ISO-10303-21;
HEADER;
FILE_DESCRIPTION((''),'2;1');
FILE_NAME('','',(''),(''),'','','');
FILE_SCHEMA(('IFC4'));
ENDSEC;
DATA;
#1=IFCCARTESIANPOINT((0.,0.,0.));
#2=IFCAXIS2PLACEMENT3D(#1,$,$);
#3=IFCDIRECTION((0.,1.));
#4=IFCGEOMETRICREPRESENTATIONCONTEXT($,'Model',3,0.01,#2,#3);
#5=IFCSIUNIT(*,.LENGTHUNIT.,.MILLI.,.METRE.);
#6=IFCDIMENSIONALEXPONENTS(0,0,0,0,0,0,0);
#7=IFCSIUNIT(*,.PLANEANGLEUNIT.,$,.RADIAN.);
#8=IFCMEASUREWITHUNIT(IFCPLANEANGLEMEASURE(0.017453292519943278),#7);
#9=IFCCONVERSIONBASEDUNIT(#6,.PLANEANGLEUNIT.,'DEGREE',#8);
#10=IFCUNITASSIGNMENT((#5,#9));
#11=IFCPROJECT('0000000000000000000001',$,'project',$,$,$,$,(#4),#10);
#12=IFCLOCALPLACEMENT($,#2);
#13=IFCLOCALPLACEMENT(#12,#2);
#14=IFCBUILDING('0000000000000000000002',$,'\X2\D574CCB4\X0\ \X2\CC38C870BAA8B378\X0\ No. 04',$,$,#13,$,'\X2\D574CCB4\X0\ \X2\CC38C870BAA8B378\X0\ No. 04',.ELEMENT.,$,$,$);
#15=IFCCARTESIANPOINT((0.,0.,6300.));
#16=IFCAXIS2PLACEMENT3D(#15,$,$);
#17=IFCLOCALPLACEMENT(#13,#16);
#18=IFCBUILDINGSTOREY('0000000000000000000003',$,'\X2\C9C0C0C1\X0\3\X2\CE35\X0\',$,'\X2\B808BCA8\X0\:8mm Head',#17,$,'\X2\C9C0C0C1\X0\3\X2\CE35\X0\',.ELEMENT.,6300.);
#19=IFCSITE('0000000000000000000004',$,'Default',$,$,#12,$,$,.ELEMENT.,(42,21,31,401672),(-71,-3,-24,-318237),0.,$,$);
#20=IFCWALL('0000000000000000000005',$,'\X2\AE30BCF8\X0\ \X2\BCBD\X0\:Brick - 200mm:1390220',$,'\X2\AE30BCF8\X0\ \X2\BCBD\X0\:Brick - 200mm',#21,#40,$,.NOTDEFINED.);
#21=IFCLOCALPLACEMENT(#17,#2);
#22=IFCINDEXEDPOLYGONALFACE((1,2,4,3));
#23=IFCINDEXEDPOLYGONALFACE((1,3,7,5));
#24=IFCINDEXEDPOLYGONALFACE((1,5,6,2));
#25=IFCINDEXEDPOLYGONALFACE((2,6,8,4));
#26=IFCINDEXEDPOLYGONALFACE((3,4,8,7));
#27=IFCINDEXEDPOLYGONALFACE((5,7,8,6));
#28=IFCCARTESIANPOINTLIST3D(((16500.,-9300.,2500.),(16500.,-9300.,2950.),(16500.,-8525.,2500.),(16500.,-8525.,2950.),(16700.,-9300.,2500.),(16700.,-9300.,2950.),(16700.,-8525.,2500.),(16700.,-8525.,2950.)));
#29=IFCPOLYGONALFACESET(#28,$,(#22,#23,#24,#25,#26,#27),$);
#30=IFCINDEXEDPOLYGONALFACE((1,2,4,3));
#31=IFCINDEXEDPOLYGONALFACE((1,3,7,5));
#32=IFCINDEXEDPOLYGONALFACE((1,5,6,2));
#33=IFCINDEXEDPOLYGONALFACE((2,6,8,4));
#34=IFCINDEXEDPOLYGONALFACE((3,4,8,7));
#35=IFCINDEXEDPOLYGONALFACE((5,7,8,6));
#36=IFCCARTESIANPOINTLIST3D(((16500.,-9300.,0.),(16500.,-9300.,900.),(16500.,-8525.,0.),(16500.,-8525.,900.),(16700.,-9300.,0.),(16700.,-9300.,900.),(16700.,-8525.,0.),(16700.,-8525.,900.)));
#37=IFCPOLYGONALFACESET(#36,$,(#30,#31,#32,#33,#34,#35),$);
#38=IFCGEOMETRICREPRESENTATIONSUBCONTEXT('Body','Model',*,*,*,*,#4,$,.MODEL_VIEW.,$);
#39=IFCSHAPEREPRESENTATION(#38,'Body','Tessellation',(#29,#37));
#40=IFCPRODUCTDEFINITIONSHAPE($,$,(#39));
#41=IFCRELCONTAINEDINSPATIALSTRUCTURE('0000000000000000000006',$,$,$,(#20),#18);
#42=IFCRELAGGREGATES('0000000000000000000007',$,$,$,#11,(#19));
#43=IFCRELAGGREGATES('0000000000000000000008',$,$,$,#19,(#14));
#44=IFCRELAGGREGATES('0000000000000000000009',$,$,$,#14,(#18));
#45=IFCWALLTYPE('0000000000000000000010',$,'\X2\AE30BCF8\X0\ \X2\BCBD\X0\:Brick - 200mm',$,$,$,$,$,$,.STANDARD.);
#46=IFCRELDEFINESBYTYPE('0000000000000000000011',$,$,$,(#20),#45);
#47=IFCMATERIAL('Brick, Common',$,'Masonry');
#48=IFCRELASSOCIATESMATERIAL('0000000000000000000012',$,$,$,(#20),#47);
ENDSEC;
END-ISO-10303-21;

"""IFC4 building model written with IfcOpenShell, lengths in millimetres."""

from ifc_helpers import new_model, entity, si_unit, converted_unit, direction, frame, origin, place, context, subcontext, project, spatial, indexed_curve, outline, extrude, material, type_object, element, save


model = new_model("IFC4")

# Units and contexts
model_context = context("Model", 3, precision=0.01, world=origin(), true_north=direction((0.0, 1.0)))
body_context = subcontext(model_context, "Body", "Model", "MODEL_VIEW")
ifc_project = project(units=[si_unit("LENGTHUNIT", "METRE", prefix="MILLI"), converted_unit("PLANEANGLEUNIT", "DEGREE", entity("IfcPlaneAngleMeasure", 0.017453292519943278), si_unit("PLANEANGLEUNIT", "RADIAN"), dimensions=[0, 0, 0, 0, 0, 0, 0])], contexts=[model_context])

# Site, building, storey
site_placement = place(None, origin())
site = spatial("IfcSite", under=ifc_project, at=site_placement, Name="Default", CompositionType="ELEMENT", RefLatitude=(42, 21, 31, 401672), RefLongitude=(-71, -3, -24, -318237), RefElevation=0.0)
building_placement = place(site_placement, origin())
building = spatial("IfcBuilding", under=site, at=building_placement, Name="해체 참조모델 No. 04", LongName="해체 참조모델 No. 04", CompositionType="ELEMENT")
storey_placement = place(building_placement, frame((0.0, 0.0, 6300.0)))
storey = spatial("IfcBuildingStorey", under=building, at=storey_placement, Name="지상3층", ObjectType="레벨:8mm Head", LongName="지상3층", CompositionType="ELEMENT", Elevation=6300.0)

# Shared definitions
ifc_material_1 = material(Name="Brick, Common", Category="Masonry")
wall_type = type_object("IfcWallType", Name="기본 벽:Brick - 200mm", PredefinedType="STANDARD")

# Wall, opening
wall_1_placement = place(storey_placement, frame((16600.0, -9300.0, 0.0), z_axis=(0.0, 0.0, 1.0), x_axis=(0.0, 1.0, 0.0)))
wall_1 = element("IfcWall", 1, at=wall_1_placement, inside=storey, type_object=wall_type, material=ifc_material_1, Name="기본 벽:Brick - 200mm:1390220", ObjectType="기본 벽:Brick - 200mm", PredefinedType="NOTDEFINED", context=body_context, shape_type="SweptSolid", body=[
    extrude(outline(indexed_curve([(-100.0, -387.5), (100.0, -387.5), (100.0, 387.5), (-100.0, 387.5), (-100.0, -387.5)], self_intersect=False)), frame((387.5, 0.0, 2500.0), z_axis=(0.0, 0.0, 1.0), x_axis=(0.0, 1.0, 0.0)), (0.0, 0.0, 1.0), 450.0),
    extrude(outline(indexed_curve([(-100.0, -387.5), (100.0, -387.5), (100.0, 387.5), (-100.0, 387.5), (-100.0, -387.5)], self_intersect=False)), frame((387.5, 0.0, 0.0), z_axis=(0.0, 0.0, 1.0), x_axis=(0.0, 1.0, 0.0)), (0.0, 0.0, 1.0), 900.0),
])
opening_1_placement = place(wall_1_placement, origin())
element("IfcOpeningElement", 2, at=opening_1_placement, cuts=wall_1, PredefinedType="OPENING", context=body_context, shape_type="SweptSolid", body=[
    extrude(outline(indexed_curve([(-800.0, -387.5), (800.0, -387.5), (800.0, 387.5), (-800.0, 387.5), (-800.0, -387.5)], self_intersect=False)), frame((387.5, -252.4, 1700.0), z_axis=(0.0, 1.0, 0.0), x_axis=(0.0, 0.0, 1.0)), (0.0, 0.0, 1.0), 504.8),
])

save(model, "model.ifc")
